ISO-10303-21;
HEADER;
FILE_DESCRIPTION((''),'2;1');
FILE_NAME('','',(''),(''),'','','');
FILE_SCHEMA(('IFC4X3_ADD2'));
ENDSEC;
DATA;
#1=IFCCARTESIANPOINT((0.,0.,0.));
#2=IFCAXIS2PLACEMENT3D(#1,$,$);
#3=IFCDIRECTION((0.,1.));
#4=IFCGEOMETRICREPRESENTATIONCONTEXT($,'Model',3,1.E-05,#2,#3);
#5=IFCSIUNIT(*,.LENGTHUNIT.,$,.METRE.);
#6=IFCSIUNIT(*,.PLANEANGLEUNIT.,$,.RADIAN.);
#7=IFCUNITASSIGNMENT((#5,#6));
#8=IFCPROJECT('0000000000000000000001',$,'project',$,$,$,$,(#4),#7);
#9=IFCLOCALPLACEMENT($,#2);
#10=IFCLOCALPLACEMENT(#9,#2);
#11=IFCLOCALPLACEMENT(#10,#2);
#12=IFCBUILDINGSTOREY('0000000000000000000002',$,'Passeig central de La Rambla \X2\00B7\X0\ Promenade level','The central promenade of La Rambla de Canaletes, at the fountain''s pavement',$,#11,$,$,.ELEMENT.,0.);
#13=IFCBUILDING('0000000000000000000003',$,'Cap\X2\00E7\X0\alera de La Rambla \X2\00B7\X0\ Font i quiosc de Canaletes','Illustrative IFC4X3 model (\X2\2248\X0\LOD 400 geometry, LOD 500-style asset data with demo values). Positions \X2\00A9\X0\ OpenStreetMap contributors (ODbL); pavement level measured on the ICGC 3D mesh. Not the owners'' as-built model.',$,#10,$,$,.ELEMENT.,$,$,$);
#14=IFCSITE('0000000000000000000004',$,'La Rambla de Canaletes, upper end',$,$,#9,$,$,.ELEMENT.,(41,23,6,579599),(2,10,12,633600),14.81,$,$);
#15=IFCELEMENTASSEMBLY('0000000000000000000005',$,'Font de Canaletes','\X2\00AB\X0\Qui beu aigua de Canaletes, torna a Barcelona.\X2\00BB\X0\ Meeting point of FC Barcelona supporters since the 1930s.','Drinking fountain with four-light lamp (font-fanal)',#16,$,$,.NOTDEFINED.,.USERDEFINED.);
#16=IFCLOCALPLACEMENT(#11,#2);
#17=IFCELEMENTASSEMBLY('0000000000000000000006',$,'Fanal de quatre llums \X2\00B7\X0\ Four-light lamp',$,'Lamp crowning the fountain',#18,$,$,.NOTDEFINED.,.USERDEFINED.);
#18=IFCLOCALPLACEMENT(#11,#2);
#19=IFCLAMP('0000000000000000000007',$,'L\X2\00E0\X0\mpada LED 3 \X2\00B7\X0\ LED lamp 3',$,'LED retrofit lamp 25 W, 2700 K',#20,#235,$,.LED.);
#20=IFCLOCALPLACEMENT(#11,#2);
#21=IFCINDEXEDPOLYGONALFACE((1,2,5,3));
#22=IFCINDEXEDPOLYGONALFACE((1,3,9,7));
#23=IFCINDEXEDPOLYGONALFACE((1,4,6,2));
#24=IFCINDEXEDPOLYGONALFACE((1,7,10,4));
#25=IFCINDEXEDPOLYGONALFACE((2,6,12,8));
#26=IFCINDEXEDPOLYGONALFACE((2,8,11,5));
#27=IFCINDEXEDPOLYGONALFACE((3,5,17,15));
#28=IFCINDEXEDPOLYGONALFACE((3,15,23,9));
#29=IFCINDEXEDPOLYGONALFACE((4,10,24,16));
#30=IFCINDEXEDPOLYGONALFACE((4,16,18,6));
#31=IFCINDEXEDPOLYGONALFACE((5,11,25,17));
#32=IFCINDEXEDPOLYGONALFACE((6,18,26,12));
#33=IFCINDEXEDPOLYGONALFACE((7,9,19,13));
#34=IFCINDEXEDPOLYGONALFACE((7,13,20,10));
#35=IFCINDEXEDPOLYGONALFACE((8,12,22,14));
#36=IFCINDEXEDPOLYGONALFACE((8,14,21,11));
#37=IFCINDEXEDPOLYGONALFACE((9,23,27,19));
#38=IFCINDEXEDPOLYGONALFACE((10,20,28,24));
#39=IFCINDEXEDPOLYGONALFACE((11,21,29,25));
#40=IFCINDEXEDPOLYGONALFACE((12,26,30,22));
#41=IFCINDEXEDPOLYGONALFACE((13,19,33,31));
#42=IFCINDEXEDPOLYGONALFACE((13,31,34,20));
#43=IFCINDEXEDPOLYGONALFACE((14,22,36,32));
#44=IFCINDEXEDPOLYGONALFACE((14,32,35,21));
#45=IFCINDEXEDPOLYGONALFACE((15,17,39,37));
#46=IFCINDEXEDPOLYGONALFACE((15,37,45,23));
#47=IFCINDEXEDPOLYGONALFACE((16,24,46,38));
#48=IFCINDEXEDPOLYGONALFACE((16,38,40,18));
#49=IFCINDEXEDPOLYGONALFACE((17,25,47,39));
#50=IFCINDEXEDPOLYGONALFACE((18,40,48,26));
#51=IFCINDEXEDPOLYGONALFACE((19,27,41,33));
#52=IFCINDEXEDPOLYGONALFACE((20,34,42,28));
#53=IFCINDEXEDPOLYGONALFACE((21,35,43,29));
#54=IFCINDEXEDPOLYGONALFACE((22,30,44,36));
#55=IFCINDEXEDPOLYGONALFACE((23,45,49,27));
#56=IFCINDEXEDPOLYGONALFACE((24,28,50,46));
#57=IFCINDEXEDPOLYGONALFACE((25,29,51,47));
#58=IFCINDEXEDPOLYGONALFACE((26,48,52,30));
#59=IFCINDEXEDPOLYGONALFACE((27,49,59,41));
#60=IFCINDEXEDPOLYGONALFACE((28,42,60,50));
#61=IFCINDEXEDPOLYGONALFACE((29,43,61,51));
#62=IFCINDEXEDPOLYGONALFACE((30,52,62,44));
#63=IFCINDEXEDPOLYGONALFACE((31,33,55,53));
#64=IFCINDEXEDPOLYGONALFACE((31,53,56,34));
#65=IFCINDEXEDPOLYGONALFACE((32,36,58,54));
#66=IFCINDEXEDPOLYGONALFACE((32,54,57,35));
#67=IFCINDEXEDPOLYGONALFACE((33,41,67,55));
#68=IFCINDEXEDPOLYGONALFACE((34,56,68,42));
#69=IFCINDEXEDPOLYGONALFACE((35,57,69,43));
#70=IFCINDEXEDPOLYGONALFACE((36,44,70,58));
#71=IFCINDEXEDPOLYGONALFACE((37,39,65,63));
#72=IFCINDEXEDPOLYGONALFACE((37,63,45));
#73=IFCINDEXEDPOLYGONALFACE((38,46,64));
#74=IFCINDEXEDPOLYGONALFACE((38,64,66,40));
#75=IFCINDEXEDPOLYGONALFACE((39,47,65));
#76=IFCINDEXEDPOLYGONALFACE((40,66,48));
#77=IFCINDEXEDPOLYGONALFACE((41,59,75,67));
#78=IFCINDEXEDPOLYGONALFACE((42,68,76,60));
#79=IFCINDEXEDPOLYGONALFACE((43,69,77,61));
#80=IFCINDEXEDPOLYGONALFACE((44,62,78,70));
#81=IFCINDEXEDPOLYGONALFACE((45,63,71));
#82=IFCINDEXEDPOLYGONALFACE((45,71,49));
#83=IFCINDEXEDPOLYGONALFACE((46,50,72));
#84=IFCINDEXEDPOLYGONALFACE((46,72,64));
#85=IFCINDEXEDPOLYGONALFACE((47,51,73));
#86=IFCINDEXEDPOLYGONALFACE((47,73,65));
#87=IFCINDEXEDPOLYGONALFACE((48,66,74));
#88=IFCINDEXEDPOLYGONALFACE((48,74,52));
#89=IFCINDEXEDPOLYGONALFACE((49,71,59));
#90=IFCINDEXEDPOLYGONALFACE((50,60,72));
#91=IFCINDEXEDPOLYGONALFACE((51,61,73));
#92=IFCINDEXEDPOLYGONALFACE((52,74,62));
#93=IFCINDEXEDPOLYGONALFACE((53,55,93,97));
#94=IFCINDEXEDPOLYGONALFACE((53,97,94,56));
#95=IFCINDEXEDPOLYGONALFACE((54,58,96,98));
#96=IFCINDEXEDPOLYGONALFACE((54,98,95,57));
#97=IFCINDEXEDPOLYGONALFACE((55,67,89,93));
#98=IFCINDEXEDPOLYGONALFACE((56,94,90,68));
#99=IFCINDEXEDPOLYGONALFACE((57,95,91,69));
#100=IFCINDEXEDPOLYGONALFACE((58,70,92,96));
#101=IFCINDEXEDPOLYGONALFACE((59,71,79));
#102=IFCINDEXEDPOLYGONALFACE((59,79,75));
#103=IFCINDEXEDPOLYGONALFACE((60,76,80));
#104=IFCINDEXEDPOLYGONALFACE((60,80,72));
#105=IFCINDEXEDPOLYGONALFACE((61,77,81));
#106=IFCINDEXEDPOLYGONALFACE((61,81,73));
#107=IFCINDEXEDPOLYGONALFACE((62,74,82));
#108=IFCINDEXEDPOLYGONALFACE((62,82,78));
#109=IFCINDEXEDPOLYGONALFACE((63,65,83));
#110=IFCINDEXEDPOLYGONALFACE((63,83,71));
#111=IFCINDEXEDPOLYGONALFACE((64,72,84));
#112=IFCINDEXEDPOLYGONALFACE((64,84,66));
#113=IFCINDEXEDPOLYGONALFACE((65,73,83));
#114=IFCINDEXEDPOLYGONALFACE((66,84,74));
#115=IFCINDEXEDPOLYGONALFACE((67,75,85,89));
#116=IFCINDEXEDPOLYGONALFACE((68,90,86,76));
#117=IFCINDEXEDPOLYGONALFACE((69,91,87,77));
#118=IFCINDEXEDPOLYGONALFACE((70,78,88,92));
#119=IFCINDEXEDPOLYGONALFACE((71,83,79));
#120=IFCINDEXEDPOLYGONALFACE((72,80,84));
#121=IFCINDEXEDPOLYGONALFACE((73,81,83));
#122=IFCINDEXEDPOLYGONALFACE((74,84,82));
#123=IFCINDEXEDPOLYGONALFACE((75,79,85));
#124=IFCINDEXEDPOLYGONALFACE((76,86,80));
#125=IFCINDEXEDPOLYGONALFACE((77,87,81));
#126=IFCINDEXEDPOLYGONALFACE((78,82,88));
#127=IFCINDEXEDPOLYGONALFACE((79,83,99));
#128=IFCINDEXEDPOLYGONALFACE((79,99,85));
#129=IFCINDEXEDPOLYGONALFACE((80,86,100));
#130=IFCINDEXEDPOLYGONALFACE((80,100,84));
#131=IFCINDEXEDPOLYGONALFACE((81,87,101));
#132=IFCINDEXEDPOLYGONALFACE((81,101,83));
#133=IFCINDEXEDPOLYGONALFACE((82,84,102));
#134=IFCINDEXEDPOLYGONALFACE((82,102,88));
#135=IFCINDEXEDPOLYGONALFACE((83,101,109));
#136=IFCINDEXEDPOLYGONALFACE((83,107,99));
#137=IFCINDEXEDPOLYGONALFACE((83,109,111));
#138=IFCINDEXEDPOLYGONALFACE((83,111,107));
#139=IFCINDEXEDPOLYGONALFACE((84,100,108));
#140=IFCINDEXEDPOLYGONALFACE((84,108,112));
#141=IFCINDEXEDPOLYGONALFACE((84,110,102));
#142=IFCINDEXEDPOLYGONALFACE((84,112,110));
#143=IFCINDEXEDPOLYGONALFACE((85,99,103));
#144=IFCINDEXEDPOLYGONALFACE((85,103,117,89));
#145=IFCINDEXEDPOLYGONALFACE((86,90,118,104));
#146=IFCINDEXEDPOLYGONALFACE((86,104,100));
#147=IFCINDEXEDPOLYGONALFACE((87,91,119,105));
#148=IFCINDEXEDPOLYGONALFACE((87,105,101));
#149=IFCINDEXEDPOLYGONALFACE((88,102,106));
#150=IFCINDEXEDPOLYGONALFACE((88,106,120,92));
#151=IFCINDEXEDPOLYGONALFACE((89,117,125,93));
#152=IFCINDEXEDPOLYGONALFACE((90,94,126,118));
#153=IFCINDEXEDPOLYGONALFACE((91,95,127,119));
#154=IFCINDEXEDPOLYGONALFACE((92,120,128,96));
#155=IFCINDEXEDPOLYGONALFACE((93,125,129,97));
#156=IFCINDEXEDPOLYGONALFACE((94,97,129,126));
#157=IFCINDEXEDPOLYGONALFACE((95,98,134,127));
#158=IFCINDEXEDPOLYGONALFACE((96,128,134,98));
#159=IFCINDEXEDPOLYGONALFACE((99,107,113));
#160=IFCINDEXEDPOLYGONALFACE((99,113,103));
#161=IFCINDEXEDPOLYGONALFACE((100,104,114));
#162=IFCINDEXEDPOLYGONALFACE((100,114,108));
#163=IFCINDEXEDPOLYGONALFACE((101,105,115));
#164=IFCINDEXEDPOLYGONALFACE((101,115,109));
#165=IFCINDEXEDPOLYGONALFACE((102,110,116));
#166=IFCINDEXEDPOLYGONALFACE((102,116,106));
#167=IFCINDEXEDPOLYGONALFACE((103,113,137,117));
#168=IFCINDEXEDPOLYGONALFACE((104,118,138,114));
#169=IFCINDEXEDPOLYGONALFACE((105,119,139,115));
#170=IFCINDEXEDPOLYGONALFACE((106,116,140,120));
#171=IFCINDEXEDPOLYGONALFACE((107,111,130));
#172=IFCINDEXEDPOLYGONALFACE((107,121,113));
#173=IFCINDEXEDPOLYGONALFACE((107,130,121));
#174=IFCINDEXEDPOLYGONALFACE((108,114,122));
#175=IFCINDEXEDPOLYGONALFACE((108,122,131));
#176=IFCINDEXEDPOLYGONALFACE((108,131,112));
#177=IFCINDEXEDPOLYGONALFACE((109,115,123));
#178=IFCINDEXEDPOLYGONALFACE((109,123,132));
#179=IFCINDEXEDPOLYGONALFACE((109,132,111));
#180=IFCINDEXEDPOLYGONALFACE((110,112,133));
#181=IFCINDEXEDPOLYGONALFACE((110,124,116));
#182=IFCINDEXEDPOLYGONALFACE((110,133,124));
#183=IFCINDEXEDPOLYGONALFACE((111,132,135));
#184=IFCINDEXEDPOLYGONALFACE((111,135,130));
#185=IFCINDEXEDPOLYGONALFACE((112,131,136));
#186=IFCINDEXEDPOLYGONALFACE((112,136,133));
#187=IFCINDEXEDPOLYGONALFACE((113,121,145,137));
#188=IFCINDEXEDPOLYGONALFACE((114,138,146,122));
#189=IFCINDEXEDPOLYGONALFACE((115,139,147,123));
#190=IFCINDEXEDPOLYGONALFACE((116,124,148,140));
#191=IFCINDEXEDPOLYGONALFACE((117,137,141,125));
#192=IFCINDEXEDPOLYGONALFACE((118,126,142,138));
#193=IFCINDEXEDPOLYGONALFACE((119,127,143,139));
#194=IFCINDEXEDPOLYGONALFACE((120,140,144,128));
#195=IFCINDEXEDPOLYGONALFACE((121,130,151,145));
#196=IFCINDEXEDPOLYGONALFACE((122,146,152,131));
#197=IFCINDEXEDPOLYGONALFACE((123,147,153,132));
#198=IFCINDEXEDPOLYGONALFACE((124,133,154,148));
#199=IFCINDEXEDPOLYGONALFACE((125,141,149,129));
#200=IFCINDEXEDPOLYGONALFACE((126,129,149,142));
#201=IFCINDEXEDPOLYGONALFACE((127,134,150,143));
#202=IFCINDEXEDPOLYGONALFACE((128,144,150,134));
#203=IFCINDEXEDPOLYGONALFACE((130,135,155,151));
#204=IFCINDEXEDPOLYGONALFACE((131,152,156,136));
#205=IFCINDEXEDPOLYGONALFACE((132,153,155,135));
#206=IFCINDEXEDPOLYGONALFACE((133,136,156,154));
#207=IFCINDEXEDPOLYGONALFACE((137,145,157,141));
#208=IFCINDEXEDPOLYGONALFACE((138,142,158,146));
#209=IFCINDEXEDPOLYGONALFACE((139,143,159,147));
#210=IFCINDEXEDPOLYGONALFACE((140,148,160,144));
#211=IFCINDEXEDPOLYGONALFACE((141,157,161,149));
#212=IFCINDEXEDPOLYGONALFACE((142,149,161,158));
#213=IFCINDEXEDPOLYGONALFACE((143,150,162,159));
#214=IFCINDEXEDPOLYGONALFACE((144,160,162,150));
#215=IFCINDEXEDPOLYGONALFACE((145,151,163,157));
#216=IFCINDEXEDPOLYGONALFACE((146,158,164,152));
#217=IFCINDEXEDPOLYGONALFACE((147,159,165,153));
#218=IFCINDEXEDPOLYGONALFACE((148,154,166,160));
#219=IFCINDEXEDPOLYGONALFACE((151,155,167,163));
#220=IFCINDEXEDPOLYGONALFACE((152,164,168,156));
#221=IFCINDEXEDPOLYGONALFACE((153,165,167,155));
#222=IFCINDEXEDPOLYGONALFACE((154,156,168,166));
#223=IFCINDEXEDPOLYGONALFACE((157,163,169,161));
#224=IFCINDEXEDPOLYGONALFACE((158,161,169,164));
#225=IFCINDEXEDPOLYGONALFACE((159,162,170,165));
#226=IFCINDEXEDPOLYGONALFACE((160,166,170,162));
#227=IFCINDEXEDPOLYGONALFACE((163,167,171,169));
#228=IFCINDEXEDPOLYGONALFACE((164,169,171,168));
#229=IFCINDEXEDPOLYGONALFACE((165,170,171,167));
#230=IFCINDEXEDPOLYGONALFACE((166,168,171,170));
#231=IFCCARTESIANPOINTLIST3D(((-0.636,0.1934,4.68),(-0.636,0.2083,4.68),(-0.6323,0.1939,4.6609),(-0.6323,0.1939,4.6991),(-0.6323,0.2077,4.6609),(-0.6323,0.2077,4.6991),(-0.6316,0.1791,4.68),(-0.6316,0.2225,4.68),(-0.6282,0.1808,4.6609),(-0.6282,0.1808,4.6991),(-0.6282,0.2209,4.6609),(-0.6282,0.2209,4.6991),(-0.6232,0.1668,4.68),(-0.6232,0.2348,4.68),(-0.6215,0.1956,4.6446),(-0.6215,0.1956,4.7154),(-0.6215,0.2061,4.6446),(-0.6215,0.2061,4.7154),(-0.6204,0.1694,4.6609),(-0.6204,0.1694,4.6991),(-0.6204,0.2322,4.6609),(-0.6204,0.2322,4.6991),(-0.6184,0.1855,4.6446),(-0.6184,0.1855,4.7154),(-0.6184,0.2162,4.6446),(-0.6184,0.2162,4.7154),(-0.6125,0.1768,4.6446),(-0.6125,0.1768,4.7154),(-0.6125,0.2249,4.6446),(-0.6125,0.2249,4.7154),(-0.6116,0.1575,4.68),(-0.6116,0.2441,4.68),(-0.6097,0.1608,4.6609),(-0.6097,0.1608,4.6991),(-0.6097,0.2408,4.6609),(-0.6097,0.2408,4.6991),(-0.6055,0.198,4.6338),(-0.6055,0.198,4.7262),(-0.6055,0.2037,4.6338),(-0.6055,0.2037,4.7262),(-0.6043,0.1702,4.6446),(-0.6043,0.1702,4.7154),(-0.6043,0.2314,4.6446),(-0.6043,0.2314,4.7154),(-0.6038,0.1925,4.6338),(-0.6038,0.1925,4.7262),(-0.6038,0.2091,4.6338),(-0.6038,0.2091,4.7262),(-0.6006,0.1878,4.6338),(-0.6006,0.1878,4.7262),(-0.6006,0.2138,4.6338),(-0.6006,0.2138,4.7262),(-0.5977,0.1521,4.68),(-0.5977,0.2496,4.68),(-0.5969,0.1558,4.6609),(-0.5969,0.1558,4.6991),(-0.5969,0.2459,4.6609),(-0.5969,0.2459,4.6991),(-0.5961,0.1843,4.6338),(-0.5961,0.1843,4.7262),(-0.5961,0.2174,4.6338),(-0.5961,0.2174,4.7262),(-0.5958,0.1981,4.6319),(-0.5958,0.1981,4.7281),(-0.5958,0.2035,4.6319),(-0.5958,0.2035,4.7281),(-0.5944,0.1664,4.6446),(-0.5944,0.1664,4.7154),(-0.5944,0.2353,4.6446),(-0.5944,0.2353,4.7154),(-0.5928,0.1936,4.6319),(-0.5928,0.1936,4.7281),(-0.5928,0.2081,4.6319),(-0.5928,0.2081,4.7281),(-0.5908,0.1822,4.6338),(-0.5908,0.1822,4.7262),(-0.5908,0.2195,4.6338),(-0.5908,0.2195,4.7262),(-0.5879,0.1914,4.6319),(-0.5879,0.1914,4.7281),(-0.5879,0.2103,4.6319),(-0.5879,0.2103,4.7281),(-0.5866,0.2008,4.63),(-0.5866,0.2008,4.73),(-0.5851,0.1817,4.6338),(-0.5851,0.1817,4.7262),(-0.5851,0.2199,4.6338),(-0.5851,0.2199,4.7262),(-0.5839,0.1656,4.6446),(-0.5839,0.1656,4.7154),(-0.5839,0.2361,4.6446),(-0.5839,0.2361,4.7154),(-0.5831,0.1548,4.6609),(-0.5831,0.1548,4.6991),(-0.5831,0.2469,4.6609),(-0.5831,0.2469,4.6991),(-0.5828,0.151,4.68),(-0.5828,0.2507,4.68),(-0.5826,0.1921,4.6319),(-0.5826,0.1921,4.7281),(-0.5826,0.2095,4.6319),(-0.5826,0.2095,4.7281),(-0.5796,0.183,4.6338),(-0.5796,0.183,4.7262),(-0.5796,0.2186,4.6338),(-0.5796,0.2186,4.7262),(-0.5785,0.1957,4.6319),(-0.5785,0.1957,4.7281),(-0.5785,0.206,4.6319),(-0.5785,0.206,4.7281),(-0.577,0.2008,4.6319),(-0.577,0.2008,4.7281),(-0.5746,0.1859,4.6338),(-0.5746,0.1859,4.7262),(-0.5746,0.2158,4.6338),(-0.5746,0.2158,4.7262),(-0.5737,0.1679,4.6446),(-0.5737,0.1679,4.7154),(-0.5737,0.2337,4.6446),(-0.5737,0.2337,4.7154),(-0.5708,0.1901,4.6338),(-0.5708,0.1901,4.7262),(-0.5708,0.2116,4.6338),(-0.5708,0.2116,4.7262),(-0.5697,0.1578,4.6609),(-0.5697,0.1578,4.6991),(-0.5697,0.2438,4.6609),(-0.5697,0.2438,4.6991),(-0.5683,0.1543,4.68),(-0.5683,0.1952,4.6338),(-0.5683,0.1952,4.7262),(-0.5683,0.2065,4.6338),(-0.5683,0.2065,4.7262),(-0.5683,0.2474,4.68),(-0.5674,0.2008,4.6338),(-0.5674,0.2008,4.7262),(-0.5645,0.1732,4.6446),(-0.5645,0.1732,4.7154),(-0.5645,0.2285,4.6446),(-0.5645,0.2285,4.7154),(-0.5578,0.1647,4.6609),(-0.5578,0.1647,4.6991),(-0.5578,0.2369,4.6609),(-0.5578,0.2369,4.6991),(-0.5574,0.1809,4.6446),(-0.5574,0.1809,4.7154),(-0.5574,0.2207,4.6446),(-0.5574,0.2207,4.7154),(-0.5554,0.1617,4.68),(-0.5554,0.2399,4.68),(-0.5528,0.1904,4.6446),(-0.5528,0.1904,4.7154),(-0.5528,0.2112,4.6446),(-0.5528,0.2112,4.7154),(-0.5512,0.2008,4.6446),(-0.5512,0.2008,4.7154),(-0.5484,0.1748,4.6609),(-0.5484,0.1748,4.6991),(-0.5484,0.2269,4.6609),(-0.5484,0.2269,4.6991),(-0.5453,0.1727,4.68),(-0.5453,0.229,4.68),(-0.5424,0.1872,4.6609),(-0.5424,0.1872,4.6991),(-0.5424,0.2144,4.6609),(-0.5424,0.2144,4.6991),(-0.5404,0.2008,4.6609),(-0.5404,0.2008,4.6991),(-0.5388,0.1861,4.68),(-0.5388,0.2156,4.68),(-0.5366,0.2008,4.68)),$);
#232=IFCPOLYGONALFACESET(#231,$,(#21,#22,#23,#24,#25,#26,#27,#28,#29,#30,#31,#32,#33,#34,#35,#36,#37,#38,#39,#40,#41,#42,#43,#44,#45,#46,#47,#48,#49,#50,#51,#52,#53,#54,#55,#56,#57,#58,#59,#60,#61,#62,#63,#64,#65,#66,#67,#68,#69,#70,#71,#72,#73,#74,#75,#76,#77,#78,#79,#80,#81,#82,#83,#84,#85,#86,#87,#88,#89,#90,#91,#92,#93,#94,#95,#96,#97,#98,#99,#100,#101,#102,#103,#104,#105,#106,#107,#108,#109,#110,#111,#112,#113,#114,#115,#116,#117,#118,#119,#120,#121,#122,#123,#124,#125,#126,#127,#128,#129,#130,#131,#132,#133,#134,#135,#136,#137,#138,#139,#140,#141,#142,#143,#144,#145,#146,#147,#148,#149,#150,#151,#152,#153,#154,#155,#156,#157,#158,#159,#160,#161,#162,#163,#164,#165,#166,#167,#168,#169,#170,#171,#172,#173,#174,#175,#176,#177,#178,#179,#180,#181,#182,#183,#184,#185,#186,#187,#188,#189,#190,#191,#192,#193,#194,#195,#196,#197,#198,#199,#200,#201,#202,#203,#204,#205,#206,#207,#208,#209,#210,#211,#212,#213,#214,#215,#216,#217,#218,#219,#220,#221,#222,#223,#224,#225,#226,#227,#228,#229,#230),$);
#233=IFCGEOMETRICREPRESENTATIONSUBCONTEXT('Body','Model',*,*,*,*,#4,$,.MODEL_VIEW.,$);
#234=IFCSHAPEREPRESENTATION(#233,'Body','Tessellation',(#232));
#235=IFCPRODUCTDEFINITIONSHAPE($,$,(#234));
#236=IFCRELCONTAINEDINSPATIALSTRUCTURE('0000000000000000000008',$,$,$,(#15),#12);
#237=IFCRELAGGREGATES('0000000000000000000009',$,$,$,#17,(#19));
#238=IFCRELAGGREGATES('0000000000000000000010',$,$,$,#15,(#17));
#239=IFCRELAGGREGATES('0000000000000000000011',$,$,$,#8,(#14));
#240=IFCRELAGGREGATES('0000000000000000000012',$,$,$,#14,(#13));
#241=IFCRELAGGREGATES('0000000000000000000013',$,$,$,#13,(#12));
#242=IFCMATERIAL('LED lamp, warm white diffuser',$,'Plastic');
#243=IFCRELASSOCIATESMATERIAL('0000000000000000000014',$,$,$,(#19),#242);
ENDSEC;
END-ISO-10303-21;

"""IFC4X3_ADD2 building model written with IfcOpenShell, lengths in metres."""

from ifc_helpers import new_model, entity, si_unit, direction, origin, place, context, subcontext, project, spatial, material, element, aggregate, save


model = new_model("IFC4X3_ADD2")

# Units and contexts
model_context = context("Model", 3, precision=1e-05, world=origin(), true_north=direction((0.0, 1.0)))
body_context = subcontext(model_context, "Body", "Model", "MODEL_VIEW")
ifc_project = project(units=[si_unit("LENGTHUNIT", "METRE"), si_unit("PLANEANGLEUNIT", "RADIAN")], contexts=[model_context])

# Site, building, storey
site_placement = place(None, origin())
site = spatial("IfcSite", under=ifc_project, at=site_placement, Name="La Rambla de Canaletes, upper end", CompositionType="ELEMENT", RefLatitude=(41, 23, 6, 579599), RefLongitude=(2, 10, 12, 633600), RefElevation=14.81)
building_placement = place(site_placement, origin())
building = spatial("IfcBuilding", under=site, at=building_placement, Name="Capçalera de La Rambla · Font i quiosc de Canaletes", Description="Illustrative IFC4X3 model (≈LOD 400 geometry, LOD 500-style asset data with demo values). Positions © OpenStreetMap contributors (ODbL); pavement level measured on the ICGC 3D mesh. Not the owners' as-built model.", CompositionType="ELEMENT")
storey_placement = place(building_placement, origin())
storey = spatial("IfcBuildingStorey", under=building, at=storey_placement, Name="Passeig central de La Rambla · Promenade level", Description="The central promenade of La Rambla de Canaletes, at the fountain's pavement", CompositionType="ELEMENT", Elevation=0.0)

# Element assemblies, lamp
assembly_1_placement = place(building_placement, origin())
assembly_1 = element("IfcElementAssembly", 1, at=assembly_1_placement, inside=storey, Name="Font de Canaletes", Description="«Qui beu aigua de Canaletes, torna a Barcelona.» Meeting point of FC Barcelona supporters since the 1930s.", ObjectType="Drinking fountain with four-light lamp (font-fanal)", AssemblyPlace="NOTDEFINED", PredefinedType="USERDEFINED")
assembly_2_placement = place(building_placement, origin())
assembly_2 = element("IfcElementAssembly", 2, at=assembly_2_placement, Name="Fanal de quatre llums · Four-light lamp", ObjectType="Lamp crowning the fountain", AssemblyPlace="NOTDEFINED", PredefinedType="USERDEFINED")
ifc_material_1 = material(Name="LED lamp, warm white diffuser", Category="Plastic")
lamp_1_placement = place(building_placement, origin())
lamp_1 = element("IfcLamp", 3, at=lamp_1_placement, material=ifc_material_1, Name="Làmpada LED 3 · LED lamp 3", ObjectType="LED retrofit lamp 25 W, 2700 K", PredefinedType="LED", context=body_context, shape_type="SweptSolid", body=[
    entity("IfcRevolvedAreaSolid", entity("IfcArbitraryClosedProfileDef", "AREA", None, entity("IfcPolyline", [entity("IfcCartesianPoint", [0.0, -0.05]), entity("IfcCartesianPoint", [0.0191, -0.0462]), entity("IfcCartesianPoint", [0.0354, -0.0354]), entity("IfcCartesianPoint", [0.0462, -0.0191]), entity("IfcCartesianPoint", [0.05, 0.0]), entity("IfcCartesianPoint", [0.0462, 0.0191]), entity("IfcCartesianPoint", [0.0354, 0.0354]), entity("IfcCartesianPoint", [0.0191, 0.0462]), entity("IfcCartesianPoint", [0.0, 0.05]), entity("IfcCartesianPoint", [0.0, -0.05])])), entity("IfcAxis2Placement3D", entity("IfcCartesianPoint", [-0.5866, 0.2008, 4.68]), entity("IfcDirection", [0.0, -1.0, 0.0]), entity("IfcDirection", [1.0, 0.0, 0.0])), entity("IfcAxis1Placement", entity("IfcCartesianPoint", [0.0, 0.0, 0.0]), entity("IfcDirection", [0.0, 1.0, 0.0])), 6.283185),
])
aggregate(assembly_2, [lamp_1])
aggregate(assembly_1, [assembly_2])

save(model, "model.ifc")
